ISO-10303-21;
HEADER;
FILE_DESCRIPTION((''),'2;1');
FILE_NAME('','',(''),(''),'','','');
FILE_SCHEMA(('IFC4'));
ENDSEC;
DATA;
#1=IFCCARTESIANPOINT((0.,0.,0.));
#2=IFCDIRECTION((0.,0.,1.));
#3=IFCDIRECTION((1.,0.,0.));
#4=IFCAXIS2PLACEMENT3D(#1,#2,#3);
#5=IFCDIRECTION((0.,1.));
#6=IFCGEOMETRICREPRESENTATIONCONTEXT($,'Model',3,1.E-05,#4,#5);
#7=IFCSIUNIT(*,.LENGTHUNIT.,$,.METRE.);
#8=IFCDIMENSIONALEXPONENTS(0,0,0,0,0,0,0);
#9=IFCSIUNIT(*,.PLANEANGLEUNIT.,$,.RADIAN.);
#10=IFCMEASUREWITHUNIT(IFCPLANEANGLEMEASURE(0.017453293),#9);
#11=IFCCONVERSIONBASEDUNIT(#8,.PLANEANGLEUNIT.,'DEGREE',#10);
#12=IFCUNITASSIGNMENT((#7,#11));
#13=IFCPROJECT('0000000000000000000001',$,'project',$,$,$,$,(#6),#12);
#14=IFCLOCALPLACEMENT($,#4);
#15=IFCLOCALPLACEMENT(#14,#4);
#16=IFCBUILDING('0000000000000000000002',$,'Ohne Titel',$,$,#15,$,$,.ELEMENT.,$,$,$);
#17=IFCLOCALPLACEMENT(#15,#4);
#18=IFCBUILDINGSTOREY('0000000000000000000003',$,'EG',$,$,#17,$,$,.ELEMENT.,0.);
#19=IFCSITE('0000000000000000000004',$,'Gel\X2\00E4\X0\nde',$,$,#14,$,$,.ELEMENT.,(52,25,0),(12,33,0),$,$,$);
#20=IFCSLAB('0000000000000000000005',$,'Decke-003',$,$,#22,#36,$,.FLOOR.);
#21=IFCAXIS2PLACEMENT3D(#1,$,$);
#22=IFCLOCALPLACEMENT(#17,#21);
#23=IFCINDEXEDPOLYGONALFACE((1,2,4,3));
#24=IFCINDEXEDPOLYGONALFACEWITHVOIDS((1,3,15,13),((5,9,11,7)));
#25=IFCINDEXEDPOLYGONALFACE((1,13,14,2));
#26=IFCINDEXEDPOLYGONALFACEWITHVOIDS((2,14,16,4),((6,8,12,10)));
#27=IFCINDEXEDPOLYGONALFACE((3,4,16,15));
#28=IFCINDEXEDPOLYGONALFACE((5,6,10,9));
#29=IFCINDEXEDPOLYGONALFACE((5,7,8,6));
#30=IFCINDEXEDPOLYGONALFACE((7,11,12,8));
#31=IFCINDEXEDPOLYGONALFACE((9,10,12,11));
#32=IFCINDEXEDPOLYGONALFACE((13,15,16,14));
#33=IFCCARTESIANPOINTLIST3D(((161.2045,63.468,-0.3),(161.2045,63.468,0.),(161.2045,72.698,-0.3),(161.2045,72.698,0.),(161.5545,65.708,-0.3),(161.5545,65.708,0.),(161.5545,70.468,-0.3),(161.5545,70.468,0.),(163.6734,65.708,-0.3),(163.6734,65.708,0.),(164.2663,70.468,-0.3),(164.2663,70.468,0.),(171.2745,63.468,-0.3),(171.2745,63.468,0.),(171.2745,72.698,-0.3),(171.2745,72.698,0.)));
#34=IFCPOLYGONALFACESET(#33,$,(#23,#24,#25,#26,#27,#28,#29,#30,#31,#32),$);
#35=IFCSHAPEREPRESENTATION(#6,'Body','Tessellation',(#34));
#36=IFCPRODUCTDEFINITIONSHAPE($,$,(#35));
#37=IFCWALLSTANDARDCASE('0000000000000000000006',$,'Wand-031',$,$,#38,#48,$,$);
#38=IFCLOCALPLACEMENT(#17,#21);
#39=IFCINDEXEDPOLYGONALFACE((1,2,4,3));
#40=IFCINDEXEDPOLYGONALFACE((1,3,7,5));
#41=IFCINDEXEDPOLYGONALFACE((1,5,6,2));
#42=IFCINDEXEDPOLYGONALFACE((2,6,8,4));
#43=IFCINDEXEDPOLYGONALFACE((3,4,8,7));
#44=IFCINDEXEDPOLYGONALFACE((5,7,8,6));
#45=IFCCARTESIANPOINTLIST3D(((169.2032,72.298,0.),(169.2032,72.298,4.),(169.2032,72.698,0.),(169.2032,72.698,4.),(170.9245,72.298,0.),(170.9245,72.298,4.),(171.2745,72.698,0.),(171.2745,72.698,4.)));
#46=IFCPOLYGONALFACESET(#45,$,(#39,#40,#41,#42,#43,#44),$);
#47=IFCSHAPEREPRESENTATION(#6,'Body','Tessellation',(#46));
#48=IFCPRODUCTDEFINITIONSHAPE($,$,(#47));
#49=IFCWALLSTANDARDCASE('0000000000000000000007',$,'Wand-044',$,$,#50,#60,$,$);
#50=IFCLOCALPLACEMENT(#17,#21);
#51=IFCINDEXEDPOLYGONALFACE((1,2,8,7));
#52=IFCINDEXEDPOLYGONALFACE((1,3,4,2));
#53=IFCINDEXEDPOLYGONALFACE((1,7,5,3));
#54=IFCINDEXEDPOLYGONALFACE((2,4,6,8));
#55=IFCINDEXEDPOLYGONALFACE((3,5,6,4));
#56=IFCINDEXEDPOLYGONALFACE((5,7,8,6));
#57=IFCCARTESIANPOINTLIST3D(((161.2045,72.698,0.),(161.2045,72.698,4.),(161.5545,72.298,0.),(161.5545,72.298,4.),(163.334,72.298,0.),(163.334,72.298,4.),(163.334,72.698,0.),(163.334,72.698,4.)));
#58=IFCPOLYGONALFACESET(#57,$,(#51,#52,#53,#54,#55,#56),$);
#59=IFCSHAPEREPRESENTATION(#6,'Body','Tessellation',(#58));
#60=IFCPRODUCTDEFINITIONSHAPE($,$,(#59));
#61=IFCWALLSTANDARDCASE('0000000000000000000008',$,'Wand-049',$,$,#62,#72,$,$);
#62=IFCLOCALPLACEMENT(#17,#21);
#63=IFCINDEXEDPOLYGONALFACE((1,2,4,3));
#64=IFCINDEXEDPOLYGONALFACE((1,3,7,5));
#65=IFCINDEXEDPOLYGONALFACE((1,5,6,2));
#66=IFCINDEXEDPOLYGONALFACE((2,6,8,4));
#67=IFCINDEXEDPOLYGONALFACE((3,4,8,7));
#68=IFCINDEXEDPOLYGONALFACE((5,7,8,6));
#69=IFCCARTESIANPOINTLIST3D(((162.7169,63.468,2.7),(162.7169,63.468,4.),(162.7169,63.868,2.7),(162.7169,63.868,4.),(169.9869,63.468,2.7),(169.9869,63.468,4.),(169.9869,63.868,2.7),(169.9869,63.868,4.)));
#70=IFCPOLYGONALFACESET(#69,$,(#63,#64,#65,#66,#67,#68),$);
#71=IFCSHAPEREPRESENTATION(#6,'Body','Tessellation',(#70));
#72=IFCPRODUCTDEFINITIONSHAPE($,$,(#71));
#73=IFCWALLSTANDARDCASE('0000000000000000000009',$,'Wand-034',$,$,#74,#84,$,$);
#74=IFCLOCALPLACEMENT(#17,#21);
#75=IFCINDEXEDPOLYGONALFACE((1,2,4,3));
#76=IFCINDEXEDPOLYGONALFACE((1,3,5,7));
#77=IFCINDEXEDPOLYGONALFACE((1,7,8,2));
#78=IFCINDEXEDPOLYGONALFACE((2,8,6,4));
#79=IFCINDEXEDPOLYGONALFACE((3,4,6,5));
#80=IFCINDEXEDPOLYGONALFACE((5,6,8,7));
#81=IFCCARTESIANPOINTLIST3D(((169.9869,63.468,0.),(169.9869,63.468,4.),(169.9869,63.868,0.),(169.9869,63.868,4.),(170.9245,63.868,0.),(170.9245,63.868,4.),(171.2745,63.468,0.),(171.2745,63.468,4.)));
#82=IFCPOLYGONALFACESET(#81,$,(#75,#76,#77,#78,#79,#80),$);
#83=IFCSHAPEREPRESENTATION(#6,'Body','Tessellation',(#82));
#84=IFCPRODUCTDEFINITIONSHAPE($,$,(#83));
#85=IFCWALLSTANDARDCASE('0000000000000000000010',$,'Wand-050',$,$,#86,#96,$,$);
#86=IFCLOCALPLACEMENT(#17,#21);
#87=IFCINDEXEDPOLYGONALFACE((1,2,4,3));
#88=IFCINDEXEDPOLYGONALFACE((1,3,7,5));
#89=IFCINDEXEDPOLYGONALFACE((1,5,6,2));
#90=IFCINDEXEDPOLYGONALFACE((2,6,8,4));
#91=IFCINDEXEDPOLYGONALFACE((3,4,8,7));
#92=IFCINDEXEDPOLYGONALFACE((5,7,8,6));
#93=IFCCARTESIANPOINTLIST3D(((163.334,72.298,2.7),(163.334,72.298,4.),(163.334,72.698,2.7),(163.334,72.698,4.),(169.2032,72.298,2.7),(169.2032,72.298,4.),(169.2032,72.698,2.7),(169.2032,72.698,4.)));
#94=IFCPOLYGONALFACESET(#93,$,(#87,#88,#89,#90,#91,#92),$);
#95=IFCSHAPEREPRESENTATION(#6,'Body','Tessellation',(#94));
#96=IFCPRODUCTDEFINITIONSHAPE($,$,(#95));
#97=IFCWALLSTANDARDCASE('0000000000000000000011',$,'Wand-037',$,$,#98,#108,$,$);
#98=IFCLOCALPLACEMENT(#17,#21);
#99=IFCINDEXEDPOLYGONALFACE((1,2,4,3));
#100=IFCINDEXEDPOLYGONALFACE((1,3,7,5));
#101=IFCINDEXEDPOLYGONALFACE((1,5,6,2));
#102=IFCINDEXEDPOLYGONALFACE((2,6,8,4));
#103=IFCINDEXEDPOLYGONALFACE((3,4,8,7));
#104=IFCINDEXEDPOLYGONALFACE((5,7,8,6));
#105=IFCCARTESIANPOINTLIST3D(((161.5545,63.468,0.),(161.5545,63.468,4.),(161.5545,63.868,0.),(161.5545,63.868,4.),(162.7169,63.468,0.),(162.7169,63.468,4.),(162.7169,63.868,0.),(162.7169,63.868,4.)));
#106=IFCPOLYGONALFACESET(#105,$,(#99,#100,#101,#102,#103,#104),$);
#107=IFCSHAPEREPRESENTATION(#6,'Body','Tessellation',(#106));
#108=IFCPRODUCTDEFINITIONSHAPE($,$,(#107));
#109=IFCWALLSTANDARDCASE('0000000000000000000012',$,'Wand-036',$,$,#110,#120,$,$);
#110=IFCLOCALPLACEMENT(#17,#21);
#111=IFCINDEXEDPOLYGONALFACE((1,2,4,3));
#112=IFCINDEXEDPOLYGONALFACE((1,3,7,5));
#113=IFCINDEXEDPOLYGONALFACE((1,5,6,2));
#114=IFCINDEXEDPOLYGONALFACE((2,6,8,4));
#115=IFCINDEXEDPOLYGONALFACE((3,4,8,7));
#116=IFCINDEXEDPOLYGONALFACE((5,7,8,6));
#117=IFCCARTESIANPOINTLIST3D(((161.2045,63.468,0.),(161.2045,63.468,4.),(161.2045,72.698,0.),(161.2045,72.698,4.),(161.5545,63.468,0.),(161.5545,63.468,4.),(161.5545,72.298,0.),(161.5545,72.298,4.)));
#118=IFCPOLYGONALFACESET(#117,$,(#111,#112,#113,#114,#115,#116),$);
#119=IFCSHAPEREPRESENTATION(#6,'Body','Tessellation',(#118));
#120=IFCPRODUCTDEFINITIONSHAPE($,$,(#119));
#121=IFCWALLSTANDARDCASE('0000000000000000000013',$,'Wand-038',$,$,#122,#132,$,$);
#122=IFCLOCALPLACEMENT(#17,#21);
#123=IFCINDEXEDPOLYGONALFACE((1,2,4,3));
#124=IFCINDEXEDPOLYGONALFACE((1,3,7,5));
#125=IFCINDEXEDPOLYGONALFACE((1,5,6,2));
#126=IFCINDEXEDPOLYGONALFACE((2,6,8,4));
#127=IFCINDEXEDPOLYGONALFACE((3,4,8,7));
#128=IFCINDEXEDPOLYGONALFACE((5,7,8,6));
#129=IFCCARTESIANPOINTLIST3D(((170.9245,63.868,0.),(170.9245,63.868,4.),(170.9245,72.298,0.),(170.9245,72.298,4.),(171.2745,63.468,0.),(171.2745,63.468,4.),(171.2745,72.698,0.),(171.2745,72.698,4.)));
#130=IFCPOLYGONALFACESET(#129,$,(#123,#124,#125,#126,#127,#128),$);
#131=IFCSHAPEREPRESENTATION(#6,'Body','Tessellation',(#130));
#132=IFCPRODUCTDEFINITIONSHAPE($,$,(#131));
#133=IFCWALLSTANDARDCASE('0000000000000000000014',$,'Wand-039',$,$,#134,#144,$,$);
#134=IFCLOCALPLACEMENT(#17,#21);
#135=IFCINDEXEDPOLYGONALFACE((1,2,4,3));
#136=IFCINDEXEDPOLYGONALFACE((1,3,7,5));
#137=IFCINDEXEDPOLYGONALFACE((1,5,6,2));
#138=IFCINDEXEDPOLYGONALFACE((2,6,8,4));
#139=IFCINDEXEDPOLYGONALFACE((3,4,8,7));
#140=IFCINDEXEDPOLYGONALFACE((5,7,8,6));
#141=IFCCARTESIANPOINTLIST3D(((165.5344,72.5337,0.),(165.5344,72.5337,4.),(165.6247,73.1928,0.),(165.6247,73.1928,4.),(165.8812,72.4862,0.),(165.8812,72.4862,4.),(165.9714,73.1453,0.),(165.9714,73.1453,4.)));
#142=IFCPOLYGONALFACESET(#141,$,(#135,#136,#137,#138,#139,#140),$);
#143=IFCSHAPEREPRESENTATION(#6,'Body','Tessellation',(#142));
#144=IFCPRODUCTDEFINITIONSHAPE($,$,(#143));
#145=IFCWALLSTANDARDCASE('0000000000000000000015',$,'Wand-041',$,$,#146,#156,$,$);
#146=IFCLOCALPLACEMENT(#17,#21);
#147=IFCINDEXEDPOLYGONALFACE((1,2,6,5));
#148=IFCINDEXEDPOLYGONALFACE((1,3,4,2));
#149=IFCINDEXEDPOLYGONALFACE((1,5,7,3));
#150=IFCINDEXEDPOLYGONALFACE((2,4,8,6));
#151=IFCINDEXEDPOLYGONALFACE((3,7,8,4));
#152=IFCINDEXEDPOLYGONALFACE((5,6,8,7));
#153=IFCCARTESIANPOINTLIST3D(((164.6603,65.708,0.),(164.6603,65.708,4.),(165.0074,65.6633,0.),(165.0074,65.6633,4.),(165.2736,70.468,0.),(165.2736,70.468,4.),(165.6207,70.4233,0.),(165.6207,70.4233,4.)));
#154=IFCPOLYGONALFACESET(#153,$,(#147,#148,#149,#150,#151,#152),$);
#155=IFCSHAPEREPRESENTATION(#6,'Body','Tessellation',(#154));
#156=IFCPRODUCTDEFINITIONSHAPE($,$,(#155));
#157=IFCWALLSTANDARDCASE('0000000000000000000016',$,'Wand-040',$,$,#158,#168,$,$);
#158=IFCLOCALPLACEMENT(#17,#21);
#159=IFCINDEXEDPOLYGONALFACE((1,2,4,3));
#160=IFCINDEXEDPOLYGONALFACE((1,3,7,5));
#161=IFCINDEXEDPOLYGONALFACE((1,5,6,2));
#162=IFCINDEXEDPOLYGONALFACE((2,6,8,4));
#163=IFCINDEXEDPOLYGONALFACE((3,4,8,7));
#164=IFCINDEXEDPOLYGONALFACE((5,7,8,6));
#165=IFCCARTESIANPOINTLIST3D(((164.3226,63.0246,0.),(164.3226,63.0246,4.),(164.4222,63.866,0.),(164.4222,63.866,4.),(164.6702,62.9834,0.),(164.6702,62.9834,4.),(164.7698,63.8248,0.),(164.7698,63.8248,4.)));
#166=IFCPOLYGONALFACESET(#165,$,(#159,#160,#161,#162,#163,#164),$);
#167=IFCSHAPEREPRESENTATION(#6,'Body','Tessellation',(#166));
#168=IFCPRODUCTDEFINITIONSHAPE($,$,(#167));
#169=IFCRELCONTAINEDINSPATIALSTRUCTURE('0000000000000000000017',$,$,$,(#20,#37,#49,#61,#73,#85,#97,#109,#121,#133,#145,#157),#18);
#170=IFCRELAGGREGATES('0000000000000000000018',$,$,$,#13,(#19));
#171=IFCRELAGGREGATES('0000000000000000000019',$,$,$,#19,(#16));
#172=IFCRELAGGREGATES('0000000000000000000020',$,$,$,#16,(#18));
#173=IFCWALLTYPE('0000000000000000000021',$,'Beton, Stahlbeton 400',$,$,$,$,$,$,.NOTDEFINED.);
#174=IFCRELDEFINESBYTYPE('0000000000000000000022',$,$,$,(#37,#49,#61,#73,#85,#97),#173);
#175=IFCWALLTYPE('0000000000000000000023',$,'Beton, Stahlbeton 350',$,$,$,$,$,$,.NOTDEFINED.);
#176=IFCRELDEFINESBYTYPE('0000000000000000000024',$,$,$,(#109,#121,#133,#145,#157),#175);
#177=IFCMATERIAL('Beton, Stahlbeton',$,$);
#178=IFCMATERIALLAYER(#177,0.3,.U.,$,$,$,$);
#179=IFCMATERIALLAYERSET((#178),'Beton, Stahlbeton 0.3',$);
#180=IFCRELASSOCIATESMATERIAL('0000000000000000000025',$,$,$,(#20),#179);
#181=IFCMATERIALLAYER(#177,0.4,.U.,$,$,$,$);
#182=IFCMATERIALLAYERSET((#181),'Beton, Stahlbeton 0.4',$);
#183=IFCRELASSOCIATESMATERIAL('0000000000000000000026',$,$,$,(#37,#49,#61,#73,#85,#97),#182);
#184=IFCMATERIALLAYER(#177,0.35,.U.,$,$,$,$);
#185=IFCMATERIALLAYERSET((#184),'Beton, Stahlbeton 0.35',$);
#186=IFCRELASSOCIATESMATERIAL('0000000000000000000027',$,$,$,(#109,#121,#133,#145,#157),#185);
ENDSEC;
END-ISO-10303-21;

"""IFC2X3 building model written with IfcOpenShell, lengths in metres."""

from ifc_helpers import new_model, entity, si_unit, converted_unit, direction, frame, origin_with_axes, place, context, project, spatial, polyline, outline, extrude, material, layer, layer_set, layer_usage, type_object, element, save


model = new_model("IFC2X3")

# Units and contexts
model_context = context("Model", 3, precision=1e-05, world=origin_with_axes(), true_north=direction((0.0, 1.0)))
ifc_project = project(units=[si_unit("LENGTHUNIT", "METRE"), converted_unit("PLANEANGLEUNIT", "DEGREE", entity("IfcPlaneAngleMeasure", 0.017453293), si_unit("PLANEANGLEUNIT", "RADIAN"), dimensions=[0, 0, 0, 0, 0, 0, 0])], contexts=[model_context])

# Site, building, storey
site_placement = place(None, origin_with_axes())
site = spatial("IfcSite", under=ifc_project, at=site_placement, Name="Gelände", CompositionType="ELEMENT", RefLatitude=(52, 25, 0), RefLongitude=(12, 33, 0))
building_placement = place(site_placement, origin_with_axes())
building = spatial("IfcBuilding", under=site, at=building_placement, Name="Ohne Titel", CompositionType="ELEMENT")
storey_placement = place(building_placement, origin_with_axes())
storey = spatial("IfcBuildingStorey", under=building, at=storey_placement, Name="EG", CompositionType="ELEMENT", Elevation=0.0)

# Slab
ifc_material = material(Name="Beton, Stahlbeton")
ifc_layer_1 = layer(ifc_material, 0.3, ventilated="UNKNOWN")
ifc_layer_set_1 = layer_set([ifc_layer_1], Name="Beton, Stahlbeton 0.3")
ifc_layer_usage_1 = layer_usage(ifc_layer_set_1, "AXIS3", "NEGATIVE", 0.3)
slab_placement = place(storey_placement, frame((161.2045, 72.698, -0.3), z_axis=(0.0, 0.0, 1.0), x_axis=(1.0, 0.0, 0.0)))
element("IfcSlab", 1, at=slab_placement, inside=storey, material=ifc_layer_usage_1, Name="Decke-003", PredefinedType="FLOOR", context=model_context, shape_type="SweptSolid", body=[
    extrude(outline(polyline([(0.0, 0.0), (0.0, -9.23), (10.07, -9.23), (10.07, 0.0), (0.0, 0.0)]), holes=[polyline([(0.35, -2.23), (3.0617, -2.23), (2.4689, -6.99), (0.35, -6.99), (0.35, -2.23)])]), origin_with_axes(), (0.0, 0.0, 1.0), 0.3),
])

# Shared definitions
ifc_layer_2 = layer(ifc_material, 0.4, ventilated="UNKNOWN")
ifc_layer_set_2 = layer_set([ifc_layer_2], Name="Beton, Stahlbeton 0.4")
wall_type_1 = type_object("IfcWallType", Name="Beton, Stahlbeton 400", PredefinedType="NOTDEFINED")

# Wall
ifc_layer_usage_2 = layer_usage(ifc_layer_set_2, "AXIS2", "POSITIVE", -0.2)
wall_1_placement = place(storey_placement, frame((169.2032, 72.498, 0.0), z_axis=(0.0, 0.0, 1.0), x_axis=(1.0, 0.0, 0.0)))
element("IfcWallStandardCase", 2, at=wall_1_placement, inside=storey, type_object=wall_type_1, material=ifc_layer_usage_2, Name="Wand-031", context=model_context, shape_type="SweptSolid", body=[
    extrude(outline(polyline([(0.0, -0.2), (1.7213, -0.2), (2.0713, 0.2), (0.0, 0.2), (0.0, -0.2)])), origin_with_axes(), (0.0, 0.0, 1.0), 4.0),
])

# Walls
ifc_layer_usage_3 = layer_usage(ifc_layer_set_2, "AXIS2", "POSITIVE", 0.0)
wall_2_placement = place(storey_placement, frame((161.2045, 72.298, 0.0), z_axis=(0.0, 0.0, 1.0), x_axis=(1.0, 0.0, 0.0)))
element("IfcWallStandardCase", 3, at=wall_2_placement, inside=storey, type_object=wall_type_1, material=ifc_layer_usage_3, Name="Wand-044", context=model_context, shape_type="SweptSolid", body=[
    extrude(outline(polyline([(0.35, 0.0), (2.1294, 0.0), (2.1294, 0.4), (0.0, 0.4), (0.35, 0.0)])), origin_with_axes(), (0.0, 0.0, 1.0), 4.0),
])
ifc_layer_usage_4 = layer_usage(ifc_layer_set_2, "AXIS2", "NEGATIVE", 0.0)
wall_3_placement = place(storey_placement, frame((162.7169, 63.868, 2.7), z_axis=(0.0, 0.0, 1.0), x_axis=(1.0, 0.0, 0.0)))
element("IfcWallStandardCase", 4, at=wall_3_placement, inside=storey, type_object=wall_type_1, material=ifc_layer_usage_4, Name="Wand-049", context=model_context, shape_type="SweptSolid", body=[
    extrude(outline(polyline([(0.0, -0.4), (7.27, -0.4), (7.27, 0.0), (0.0, 0.0), (0.0, -0.4)])), origin_with_axes(), (0.0, 0.0, 1.0), 1.3),
])
ifc_layer_usage_5 = layer_usage(ifc_layer_set_2, "AXIS2", "POSITIVE", -0.2)
wall_4_placement = place(storey_placement, frame((169.9869, 63.668, 0.0), z_axis=(0.0, 0.0, 1.0), x_axis=(1.0, 0.0, 0.0)))
element("IfcWallStandardCase", 5, at=wall_4_placement, inside=storey, type_object=wall_type_1, material=ifc_layer_usage_5, Name="Wand-034", context=model_context, shape_type="SweptSolid", body=[
    extrude(outline(polyline([(0.0, -0.2), (1.2877, -0.2), (0.9377, 0.2), (0.0, 0.2), (0.0, -0.2)])), origin_with_axes(), (0.0, 0.0, 1.0), 4.0),
])
ifc_layer_usage_6 = layer_usage(ifc_layer_set_2, "AXIS2", "NEGATIVE", 0.0)
wall_5_placement = place(storey_placement, frame((163.334, 72.698, 2.7), z_axis=(0.0, 0.0, 1.0), x_axis=(1.0, 0.0, 0.0)))
element("IfcWallStandardCase", 6, at=wall_5_placement, inside=storey, type_object=wall_type_1, material=ifc_layer_usage_6, Name="Wand-050", context=model_context, shape_type="SweptSolid", body=[
    extrude(outline(polyline([(0.0, -0.4), (5.8693, -0.4), (5.8693, 0.0), (0.0, 0.0), (0.0, -0.4)])), origin_with_axes(), (0.0, 0.0, 1.0), 1.3),
])

# Walls
ifc_layer_usage_7 = layer_usage(ifc_layer_set_2, "AXIS2", "POSITIVE", 0.0)
wall_6_placement = place(storey_placement, frame((162.7169, 63.868, 0.0), z_axis=(0.0, 0.0, 1.0), x_axis=(-1.0, 0.0, 0.0)))
element("IfcWallStandardCase", 7, at=wall_6_placement, inside=storey, type_object=wall_type_1, material=ifc_layer_usage_7, Name="Wand-037", context=model_context, shape_type="SweptSolid", body=[
    extrude(outline(polyline([(0.0, 0.0), (1.1624, 0.0), (1.1624, 0.4), (0.0, 0.4), (0.0, 0.0)])), origin_with_axes(), (0.0, 0.0, 1.0), 4.0),
])
ifc_layer_3 = layer(ifc_material, 0.35, ventilated="UNKNOWN")
ifc_layer_set_3 = layer_set([ifc_layer_3], Name="Beton, Stahlbeton 0.35")
ifc_layer_usage_8 = layer_usage(ifc_layer_set_3, "AXIS2", "POSITIVE", 0.0)
wall_type_2 = type_object("IfcWallType", Name="Beton, Stahlbeton 350", PredefinedType="NOTDEFINED")
wall_7_placement = place(storey_placement, frame((161.2045, 72.298, 0.0), z_axis=(0.0, 0.0, 1.0), x_axis=(0.0, -1.0, 0.0)))
element("IfcWallStandardCase", 8, at=wall_7_placement, inside=storey, type_object=wall_type_2, material=ifc_layer_usage_8, Name="Wand-036", context=model_context, shape_type="SweptSolid", body=[
    extrude(outline(polyline([(-0.4, 0.0), (8.83, 0.0), (8.83, 0.35), (0.0, 0.35), (-0.4, 0.0)])), origin_with_axes(), (0.0, 0.0, 1.0), 4.0),
])
ifc_layer_usage_9 = layer_usage(ifc_layer_set_3, "AXIS2", "NEGATIVE", 0.0)
wall_8_placement = place(storey_placement, frame((171.2745, 72.498, 0.0), z_axis=(0.0, 0.0, 1.0), x_axis=(0.0, -1.0, 0.0)))
element("IfcWallStandardCase", 9, at=wall_8_placement, inside=storey, type_object=wall_type_2, material=ifc_layer_usage_9, Name="Wand-038", context=model_context, shape_type="SweptSolid", body=[
    extrude(outline(polyline([(0.2, -0.35), (8.63, -0.35), (9.03, 0.0), (-0.2, 0.0), (0.2, -0.35)])), origin_with_axes(), (0.0, 0.0, 1.0), 4.0),
])
ifc_layer_usage_10 = layer_usage(ifc_layer_set_3, "AXIS2", "NEGATIVE", 0.0)
wall_9_placement = place(storey_placement, frame((165.9714, 73.1453, 0.0), z_axis=(0.0, 0.0, 1.0), x_axis=(-0.135608, -0.990763, 0.0)))
element("IfcWallStandardCase", 10, at=wall_9_placement, inside=storey, type_object=wall_type_2, material=ifc_layer_usage_10, Name="Wand-039", context=model_context, shape_type="SweptSolid", body=[
    extrude(outline(polyline([(0.0, -0.35), (0.6653, -0.35), (0.6653, 0.0), (0.0, 0.0), (0.0, -0.35)])), origin_with_axes(), (0.0, 0.0, 1.0), 4.0),
])
ifc_layer_usage_11 = layer_usage(ifc_layer_set_3, "AXIS2", "NEGATIVE", 0.0)
wall_10_placement = place(storey_placement, frame((164.6603, 65.708, 0.0), z_axis=(0.0, 0.0, 1.0), x_axis=(0.127787, 0.991802, 0.0)))
element("IfcWallStandardCase", 11, at=wall_10_placement, inside=storey, type_object=wall_type_2, material=ifc_layer_usage_11, Name="Wand-041", context=model_context, shape_type="SweptSolid", body=[
    extrude(outline(polyline([(0.0, -0.35), (4.7993, -0.35), (4.7993, 0.0), (0.0, 0.0), (0.0, -0.35)])), origin_with_axes(), (0.0, 0.0, 1.0), 4.0),
])
ifc_layer_usage_12 = layer_usage(ifc_layer_set_3, "AXIS2", "NEGATIVE", 0.0)
wall_11_placement = place(storey_placement, frame((164.3226, 63.0246, 0.0), z_axis=(0.0, 0.0, 1.0), x_axis=(0.117591, 0.993062, 0.0)))
element("IfcWallStandardCase", 12, at=wall_11_placement, inside=storey, type_object=wall_type_2, material=ifc_layer_usage_12, Name="Wand-040", context=model_context, shape_type="SweptSolid", body=[
    extrude(outline(polyline([(0.0, -0.35), (0.8472, -0.35), (0.8472, 0.0), (0.0, 0.0), (0.0, -0.35)])), origin_with_axes(), (0.0, 0.0, 1.0), 4.0),
])

save(model, "model.ifc")
